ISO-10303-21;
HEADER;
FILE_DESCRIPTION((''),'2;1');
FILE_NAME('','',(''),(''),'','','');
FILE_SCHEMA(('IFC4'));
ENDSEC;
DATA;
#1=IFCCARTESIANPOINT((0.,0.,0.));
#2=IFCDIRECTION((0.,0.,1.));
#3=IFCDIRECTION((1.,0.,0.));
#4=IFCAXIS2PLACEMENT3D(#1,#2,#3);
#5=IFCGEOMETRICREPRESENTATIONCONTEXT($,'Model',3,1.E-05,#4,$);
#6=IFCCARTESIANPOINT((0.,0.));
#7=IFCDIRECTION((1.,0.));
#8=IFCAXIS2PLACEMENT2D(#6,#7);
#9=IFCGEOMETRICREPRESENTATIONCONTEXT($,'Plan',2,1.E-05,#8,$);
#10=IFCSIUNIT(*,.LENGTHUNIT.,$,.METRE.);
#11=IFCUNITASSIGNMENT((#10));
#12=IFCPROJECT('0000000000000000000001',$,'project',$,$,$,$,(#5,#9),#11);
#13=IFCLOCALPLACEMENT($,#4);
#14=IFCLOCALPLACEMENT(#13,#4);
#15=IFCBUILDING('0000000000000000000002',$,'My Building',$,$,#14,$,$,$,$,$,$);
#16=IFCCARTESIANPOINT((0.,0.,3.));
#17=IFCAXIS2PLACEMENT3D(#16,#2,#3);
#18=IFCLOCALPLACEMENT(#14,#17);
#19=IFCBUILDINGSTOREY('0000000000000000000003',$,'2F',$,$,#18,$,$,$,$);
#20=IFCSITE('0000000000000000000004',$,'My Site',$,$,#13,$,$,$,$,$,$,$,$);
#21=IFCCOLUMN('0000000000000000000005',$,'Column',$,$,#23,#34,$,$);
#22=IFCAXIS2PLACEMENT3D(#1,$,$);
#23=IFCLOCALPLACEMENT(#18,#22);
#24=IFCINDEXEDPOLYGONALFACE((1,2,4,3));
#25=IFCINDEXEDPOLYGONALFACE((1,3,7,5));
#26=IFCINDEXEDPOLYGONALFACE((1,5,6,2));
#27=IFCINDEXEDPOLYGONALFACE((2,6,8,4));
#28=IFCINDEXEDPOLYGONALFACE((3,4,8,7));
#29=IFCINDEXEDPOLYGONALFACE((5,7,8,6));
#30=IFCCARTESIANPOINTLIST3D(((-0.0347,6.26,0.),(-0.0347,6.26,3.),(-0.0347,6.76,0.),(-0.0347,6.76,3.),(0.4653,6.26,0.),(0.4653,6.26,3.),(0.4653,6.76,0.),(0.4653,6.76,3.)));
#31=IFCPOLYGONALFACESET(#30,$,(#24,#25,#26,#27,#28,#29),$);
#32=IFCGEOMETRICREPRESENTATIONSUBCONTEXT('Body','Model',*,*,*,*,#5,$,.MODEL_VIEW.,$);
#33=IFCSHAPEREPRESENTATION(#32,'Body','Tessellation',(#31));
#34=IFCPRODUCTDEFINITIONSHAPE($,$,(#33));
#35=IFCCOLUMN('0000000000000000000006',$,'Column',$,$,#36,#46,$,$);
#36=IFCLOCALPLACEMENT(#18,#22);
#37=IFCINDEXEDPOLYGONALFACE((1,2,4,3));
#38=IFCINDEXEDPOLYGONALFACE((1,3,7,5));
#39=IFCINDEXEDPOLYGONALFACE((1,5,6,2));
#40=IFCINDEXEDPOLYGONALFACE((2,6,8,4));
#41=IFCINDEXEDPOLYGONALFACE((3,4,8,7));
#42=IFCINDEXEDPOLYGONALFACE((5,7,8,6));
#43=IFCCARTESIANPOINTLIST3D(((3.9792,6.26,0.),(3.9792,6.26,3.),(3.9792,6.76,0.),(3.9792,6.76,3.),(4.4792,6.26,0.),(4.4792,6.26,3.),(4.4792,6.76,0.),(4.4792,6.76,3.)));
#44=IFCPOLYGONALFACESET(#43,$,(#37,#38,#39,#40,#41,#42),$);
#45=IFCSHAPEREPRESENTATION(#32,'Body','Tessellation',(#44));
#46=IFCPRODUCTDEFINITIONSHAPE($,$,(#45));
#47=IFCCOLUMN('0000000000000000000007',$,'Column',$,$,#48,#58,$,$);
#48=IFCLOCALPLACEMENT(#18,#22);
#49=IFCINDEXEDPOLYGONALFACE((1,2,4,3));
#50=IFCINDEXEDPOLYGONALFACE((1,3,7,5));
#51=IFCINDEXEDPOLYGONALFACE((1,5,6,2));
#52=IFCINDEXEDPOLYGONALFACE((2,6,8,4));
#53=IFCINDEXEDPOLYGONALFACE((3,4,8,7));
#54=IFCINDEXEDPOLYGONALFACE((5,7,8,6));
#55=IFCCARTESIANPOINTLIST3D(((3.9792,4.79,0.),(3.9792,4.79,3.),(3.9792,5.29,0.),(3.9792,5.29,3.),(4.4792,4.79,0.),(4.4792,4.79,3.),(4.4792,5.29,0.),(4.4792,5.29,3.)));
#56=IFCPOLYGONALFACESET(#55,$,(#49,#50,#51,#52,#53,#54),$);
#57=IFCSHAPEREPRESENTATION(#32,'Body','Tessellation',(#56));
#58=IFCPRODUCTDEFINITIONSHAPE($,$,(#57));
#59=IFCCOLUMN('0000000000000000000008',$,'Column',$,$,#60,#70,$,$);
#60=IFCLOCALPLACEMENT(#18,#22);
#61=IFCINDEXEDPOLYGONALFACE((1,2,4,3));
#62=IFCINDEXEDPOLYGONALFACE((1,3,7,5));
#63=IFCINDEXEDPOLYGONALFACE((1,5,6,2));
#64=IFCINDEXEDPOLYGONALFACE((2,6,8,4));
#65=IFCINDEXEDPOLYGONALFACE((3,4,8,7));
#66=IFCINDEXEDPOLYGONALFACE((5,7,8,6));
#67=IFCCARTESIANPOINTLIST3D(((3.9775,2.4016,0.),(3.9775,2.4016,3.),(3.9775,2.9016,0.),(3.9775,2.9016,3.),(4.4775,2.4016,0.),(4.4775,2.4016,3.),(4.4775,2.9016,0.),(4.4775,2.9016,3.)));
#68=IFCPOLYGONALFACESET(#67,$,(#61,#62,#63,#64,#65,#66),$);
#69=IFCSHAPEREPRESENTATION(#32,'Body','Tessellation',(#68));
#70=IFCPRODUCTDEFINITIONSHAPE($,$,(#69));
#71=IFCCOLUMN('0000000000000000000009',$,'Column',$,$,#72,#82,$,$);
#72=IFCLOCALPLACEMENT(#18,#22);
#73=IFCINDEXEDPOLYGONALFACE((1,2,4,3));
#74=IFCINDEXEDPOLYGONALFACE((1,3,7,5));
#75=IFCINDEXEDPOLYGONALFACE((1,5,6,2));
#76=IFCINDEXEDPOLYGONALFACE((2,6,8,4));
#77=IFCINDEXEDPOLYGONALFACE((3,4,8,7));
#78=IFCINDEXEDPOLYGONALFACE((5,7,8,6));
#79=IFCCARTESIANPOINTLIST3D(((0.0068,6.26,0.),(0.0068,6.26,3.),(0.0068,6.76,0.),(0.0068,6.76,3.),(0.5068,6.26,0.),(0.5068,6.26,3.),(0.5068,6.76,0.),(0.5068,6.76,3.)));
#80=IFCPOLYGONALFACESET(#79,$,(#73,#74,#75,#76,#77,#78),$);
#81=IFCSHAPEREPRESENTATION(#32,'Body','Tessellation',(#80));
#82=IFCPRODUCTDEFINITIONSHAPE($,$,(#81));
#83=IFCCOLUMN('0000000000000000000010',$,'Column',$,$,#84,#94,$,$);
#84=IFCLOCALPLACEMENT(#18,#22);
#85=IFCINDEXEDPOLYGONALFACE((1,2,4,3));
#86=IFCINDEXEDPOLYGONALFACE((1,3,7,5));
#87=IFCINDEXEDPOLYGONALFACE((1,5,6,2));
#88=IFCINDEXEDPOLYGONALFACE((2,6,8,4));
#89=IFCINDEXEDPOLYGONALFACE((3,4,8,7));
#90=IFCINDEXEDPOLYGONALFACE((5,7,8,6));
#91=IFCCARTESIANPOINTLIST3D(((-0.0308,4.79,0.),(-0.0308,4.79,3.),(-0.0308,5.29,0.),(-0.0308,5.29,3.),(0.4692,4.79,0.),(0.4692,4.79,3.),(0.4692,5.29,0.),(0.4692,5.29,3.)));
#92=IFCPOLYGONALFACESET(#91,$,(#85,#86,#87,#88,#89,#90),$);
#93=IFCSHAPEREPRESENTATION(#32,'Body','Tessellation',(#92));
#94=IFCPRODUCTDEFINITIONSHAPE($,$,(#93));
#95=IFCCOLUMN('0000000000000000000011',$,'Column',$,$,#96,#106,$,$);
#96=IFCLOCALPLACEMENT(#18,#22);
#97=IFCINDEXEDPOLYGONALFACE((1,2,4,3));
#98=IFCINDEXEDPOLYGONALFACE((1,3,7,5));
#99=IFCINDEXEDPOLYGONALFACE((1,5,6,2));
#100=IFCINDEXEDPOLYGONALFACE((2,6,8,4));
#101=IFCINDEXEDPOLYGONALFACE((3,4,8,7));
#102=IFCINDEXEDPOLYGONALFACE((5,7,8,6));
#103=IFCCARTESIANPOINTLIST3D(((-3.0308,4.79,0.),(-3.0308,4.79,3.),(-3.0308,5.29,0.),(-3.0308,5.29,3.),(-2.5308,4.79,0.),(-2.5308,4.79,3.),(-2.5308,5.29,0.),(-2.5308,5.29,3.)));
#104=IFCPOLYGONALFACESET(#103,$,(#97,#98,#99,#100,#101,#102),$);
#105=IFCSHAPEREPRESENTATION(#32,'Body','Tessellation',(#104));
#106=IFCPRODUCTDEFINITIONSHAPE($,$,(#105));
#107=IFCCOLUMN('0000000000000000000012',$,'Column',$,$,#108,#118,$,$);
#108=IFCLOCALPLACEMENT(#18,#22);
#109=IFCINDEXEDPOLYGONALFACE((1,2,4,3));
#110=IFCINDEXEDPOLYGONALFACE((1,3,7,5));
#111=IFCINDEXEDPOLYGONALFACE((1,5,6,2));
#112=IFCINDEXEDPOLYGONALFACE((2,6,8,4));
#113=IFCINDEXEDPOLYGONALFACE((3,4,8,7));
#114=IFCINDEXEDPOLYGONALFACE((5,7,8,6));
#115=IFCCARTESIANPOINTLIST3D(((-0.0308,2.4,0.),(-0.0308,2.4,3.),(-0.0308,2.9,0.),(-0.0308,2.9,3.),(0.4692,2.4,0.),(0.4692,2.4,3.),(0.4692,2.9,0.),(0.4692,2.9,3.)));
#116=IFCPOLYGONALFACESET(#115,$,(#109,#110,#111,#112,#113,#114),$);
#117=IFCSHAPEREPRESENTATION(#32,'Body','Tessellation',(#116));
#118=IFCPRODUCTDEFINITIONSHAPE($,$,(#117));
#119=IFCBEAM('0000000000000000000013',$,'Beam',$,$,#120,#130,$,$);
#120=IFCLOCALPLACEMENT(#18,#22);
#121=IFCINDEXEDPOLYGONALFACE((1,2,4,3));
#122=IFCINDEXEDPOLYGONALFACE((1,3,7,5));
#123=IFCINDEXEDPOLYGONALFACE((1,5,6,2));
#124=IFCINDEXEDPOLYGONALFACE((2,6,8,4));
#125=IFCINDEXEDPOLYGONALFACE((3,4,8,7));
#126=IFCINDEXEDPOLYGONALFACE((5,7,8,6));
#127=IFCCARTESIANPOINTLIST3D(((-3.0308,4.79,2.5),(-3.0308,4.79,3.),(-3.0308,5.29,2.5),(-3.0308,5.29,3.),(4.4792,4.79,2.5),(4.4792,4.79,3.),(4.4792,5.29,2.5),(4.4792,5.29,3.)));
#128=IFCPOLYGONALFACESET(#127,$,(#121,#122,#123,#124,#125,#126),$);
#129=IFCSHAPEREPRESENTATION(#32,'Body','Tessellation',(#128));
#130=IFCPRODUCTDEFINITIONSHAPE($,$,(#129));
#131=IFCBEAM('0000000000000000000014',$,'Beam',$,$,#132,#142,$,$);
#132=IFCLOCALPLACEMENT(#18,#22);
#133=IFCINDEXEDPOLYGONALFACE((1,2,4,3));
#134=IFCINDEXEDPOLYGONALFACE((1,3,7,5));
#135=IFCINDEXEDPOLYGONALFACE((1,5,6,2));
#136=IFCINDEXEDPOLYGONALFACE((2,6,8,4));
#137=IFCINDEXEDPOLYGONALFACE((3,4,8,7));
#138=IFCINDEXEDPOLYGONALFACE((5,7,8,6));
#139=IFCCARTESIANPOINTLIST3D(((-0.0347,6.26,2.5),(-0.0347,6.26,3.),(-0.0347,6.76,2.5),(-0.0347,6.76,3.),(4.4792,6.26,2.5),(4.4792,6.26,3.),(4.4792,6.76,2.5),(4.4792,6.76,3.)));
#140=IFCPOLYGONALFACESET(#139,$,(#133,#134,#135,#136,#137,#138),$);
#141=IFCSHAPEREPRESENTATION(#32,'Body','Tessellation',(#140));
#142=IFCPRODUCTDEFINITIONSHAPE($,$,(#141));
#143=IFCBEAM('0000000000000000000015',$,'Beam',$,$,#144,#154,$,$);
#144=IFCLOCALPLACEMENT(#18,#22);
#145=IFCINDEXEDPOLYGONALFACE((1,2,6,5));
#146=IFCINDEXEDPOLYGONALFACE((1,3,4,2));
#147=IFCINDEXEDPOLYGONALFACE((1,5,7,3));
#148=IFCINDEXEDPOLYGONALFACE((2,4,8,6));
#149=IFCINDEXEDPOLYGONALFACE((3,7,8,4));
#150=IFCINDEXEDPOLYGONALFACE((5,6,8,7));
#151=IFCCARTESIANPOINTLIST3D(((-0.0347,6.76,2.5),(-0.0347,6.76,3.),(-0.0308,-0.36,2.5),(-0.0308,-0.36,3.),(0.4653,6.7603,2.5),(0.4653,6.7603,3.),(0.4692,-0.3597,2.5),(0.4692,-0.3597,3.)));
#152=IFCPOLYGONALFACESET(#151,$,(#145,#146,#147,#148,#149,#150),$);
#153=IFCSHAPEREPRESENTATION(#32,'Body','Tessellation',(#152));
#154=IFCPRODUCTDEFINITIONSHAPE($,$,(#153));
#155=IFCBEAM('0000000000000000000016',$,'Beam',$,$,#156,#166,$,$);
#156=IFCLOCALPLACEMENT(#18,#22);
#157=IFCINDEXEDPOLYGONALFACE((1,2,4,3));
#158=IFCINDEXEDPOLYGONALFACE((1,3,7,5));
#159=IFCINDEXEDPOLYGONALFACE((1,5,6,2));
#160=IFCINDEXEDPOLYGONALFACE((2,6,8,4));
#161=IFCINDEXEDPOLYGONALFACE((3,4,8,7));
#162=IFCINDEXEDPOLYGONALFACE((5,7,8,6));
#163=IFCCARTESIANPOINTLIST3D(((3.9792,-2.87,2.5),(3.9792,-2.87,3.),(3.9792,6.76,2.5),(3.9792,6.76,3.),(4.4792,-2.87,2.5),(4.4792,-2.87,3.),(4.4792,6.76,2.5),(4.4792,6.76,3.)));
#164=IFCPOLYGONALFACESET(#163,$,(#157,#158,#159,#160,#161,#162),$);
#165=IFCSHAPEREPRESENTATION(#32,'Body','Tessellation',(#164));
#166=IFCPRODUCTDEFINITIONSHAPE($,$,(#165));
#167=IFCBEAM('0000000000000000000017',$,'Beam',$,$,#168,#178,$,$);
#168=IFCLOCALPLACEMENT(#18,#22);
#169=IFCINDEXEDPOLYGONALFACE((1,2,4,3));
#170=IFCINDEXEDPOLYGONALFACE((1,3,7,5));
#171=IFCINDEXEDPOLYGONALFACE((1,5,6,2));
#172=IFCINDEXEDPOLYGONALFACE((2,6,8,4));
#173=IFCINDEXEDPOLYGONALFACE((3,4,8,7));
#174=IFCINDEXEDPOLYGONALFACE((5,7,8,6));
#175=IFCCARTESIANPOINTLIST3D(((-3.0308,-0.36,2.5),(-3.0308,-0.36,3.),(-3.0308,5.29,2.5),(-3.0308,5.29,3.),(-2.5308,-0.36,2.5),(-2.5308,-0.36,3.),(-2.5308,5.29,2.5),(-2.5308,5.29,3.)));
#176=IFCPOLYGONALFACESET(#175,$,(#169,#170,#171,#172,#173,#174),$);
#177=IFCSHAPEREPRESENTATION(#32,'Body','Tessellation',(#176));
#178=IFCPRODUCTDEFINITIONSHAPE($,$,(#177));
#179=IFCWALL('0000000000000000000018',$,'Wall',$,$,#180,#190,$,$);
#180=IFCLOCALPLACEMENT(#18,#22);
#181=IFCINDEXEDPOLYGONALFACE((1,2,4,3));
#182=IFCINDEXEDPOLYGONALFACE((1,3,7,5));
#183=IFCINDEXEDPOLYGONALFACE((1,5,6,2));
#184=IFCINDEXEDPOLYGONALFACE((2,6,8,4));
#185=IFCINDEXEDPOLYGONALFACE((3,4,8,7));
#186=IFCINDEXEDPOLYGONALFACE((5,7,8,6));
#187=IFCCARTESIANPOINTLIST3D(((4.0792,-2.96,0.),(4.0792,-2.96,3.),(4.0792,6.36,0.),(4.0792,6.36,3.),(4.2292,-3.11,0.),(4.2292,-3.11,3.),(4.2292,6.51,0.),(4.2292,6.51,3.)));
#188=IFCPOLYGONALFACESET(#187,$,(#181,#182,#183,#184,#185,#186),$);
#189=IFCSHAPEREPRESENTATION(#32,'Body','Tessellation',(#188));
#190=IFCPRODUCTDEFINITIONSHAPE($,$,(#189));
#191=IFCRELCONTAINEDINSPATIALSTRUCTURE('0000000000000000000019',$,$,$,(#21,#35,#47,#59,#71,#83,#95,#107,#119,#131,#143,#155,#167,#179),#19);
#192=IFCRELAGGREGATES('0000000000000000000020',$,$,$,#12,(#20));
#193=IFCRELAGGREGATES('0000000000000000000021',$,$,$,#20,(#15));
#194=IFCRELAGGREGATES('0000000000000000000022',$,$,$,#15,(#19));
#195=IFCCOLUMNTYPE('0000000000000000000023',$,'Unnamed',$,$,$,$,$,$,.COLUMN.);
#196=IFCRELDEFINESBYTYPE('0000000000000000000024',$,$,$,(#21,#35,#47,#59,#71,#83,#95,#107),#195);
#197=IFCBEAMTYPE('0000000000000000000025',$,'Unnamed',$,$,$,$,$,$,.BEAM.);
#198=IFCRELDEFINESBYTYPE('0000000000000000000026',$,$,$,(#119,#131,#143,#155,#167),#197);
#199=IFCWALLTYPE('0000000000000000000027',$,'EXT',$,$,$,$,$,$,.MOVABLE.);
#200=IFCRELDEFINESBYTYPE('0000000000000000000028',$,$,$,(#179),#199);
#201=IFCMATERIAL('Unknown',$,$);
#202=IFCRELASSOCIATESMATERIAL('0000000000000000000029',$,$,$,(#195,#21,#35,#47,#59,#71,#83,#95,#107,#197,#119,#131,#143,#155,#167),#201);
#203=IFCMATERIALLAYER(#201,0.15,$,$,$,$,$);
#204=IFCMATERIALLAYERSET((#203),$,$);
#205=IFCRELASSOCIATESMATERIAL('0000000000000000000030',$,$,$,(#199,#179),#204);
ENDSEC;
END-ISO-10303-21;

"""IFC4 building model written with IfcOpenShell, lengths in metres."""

from ifc_helpers import new_model, si_unit, frame, origin_with_axes, origin_2d_with_axis, place, context, subcontext, project, spatial, line, indexed_curve, rectangle, outline, extrude, material, layer, layer_set, layer_usage, material_profile, profile_set, profile_usage, type_object, element, save


model = new_model("IFC4")

# Units and contexts
model_context = context("Model", 3, precision=1e-05, world=origin_with_axes())
plan_context = context("Plan", 2, precision=1e-05, world=origin_2d_with_axis())
body_context_1 = subcontext(model_context, "Body", "Model", "MODEL_VIEW")
ifc_project = project(units=[si_unit("LENGTHUNIT", "METRE")], contexts=[model_context, plan_context])

# Site, building, storey
site_placement = place(None, origin_with_axes())
site = spatial("IfcSite", under=ifc_project, at=site_placement, Name="My Site")
building_placement = place(site_placement, origin_with_axes())
building = spatial("IfcBuilding", under=site, at=building_placement, Name="My Building")
storey_placement = place(building_placement, frame((0.0, 0.0, 3.0), z_axis=(0.0, 0.0, 1.0), x_axis=(1.0, 0.0, 0.0)))
storey = spatial("IfcBuildingStorey", under=building, at=storey_placement, Name="2F")

# Columns
ifc_material = material(Name="Unknown")
ifc_material_profile_1 = material_profile(ifc_material, rectangle(XDim=0.5, YDim=0.5))
ifc_profile_set_1 = profile_set([ifc_material_profile_1])
ifc_profile_usage_1 = profile_usage(ifc_profile_set_1, cardinal=5)
column_type = type_object("IfcColumnType", Name="Unnamed", PredefinedType="COLUMN", material=ifc_profile_set_1)
column_1_placement = place(storey_placement, frame((0.2153, 6.51, 0.0), z_axis=(0.0, 0.0, 1.0), x_axis=(1.0, 0.0, 0.0)))
element("IfcColumn", 1, at=column_1_placement, inside=storey, type_object=column_type, material=ifc_profile_usage_1, Name="Column", context=body_context_1, shape_type="SweptSolid", body=[
    extrude(rectangle(XDim=0.5, YDim=0.5), origin_with_axes(), (0.0, 0.0, 1.0), 3.0),
])
ifc_profile_usage_2 = profile_usage(ifc_profile_set_1, cardinal=5)
column_2_placement = place(storey_placement, frame((4.2292, 6.51, 0.0), z_axis=(0.0, 0.0, 1.0), x_axis=(1.0, 0.0, 0.0)))
element("IfcColumn", 2, at=column_2_placement, inside=storey, type_object=column_type, material=ifc_profile_usage_2, Name="Column", context=body_context_1, shape_type="SweptSolid", body=[
    extrude(rectangle(XDim=0.5, YDim=0.5), origin_with_axes(), (0.0, 0.0, 1.0), 3.0),
])
ifc_profile_usage_3 = profile_usage(ifc_profile_set_1, cardinal=7)
column_3_placement = place(storey_placement, frame((4.4792, 5.29, 0.0), z_axis=(0.0, 0.0, 1.0), x_axis=(1.0, 0.0, 0.0)))
element("IfcColumn", 3, at=column_3_placement, inside=storey, type_object=column_type, material=ifc_profile_usage_3, Name="Column", context=body_context_1, shape_type="SweptSolid", body=[
    extrude(rectangle(XDim=0.5, YDim=0.5), frame((-0.25, -0.25, 0.0), z_axis=(0.0, 0.0, 1.0), x_axis=(1.0, 0.0, 0.0)), (0.0, 0.0, 1.0), 3.0),
])
ifc_profile_usage_4 = profile_usage(ifc_profile_set_1, cardinal=7)
column_4_placement = place(storey_placement, frame((4.4775, 2.9016, 0.0), z_axis=(0.0, 0.0, 1.0), x_axis=(1.0, 0.0, 0.0)))
element("IfcColumn", 4, at=column_4_placement, inside=storey, type_object=column_type, material=ifc_profile_usage_4, Name="Column", context=body_context_1, shape_type="SweptSolid", body=[
    extrude(rectangle(XDim=0.5, YDim=0.5), frame((-0.25, -0.25, 0.0), z_axis=(0.0, 0.0, 1.0), x_axis=(1.0, 0.0, 0.0)), (0.0, 0.0, 1.0), 3.0),
])
ifc_profile_usage_5 = profile_usage(ifc_profile_set_1, cardinal=9)
column_5_placement = place(storey_placement, frame((0.0068, 6.76, 0.0), z_axis=(0.0, 0.0, 1.0), x_axis=(1.0, 0.0, 0.0)))
element("IfcColumn", 5, at=column_5_placement, inside=storey, type_object=column_type, material=ifc_profile_usage_5, Name="Column", context=body_context_1, shape_type="SweptSolid", body=[
    extrude(rectangle(XDim=0.5, YDim=0.5), frame((0.25, -0.25, 0.0), z_axis=(0.0, 0.0, 1.0), x_axis=(1.0, 0.0, 0.0)), (0.0, 0.0, 1.0), 3.0),
])
ifc_profile_usage_6 = profile_usage(ifc_profile_set_1, cardinal=9)
column_6_placement = place(storey_placement, frame((-0.0308, 5.29, 0.0), z_axis=(0.0, 0.0, 1.0), x_axis=(1.0, 0.0, 0.0)))
element("IfcColumn", 6, at=column_6_placement, inside=storey, type_object=column_type, material=ifc_profile_usage_6, Name="Column", context=body_context_1, shape_type="SweptSolid", body=[
    extrude(rectangle(XDim=0.5, YDim=0.5), frame((0.25, -0.25, 0.0), z_axis=(0.0, 0.0, 1.0), x_axis=(1.0, 0.0, 0.0)), (0.0, 0.0, 1.0), 3.0),
])
ifc_profile_usage_7 = profile_usage(ifc_profile_set_1, cardinal=9)
column_7_placement = place(storey_placement, frame((-3.0308, 5.29, 0.0), z_axis=(0.0, 0.0, 1.0), x_axis=(1.0, 0.0, 0.0)))
element("IfcColumn", 7, at=column_7_placement, inside=storey, type_object=column_type, material=ifc_profile_usage_7, Name="Column", context=body_context_1, shape_type="SweptSolid", body=[
    extrude(rectangle(XDim=0.5, YDim=0.5), frame((0.25, -0.25, 0.0), z_axis=(0.0, 0.0, 1.0), x_axis=(1.0, 0.0, 0.0)), (0.0, 0.0, 1.0), 3.0),
])
ifc_profile_usage_8 = profile_usage(ifc_profile_set_1, cardinal=9)
column_8_placement = place(storey_placement, frame((-0.0308, 2.9, 0.0), z_axis=(0.0, 0.0, 1.0), x_axis=(1.0, 0.0, 0.0)))
element("IfcColumn", 8, at=column_8_placement, inside=storey, type_object=column_type, material=ifc_profile_usage_8, Name="Column", context=body_context_1, shape_type="SweptSolid", body=[
    extrude(rectangle(XDim=0.5, YDim=0.5), frame((0.25, -0.25, 0.0), z_axis=(0.0, 0.0, 1.0), x_axis=(1.0, 0.0, 0.0)), (0.0, 0.0, 1.0), 3.0),
])

# Beams
ifc_material_profile_2 = material_profile(ifc_material, rectangle(XDim=0.5, YDim=0.5))
ifc_profile_set_2 = profile_set([ifc_material_profile_2])
ifc_profile_usage_9 = profile_usage(ifc_profile_set_2, cardinal=9)
beam_type = type_object("IfcBeamType", Name="Unnamed", PredefinedType="BEAM", material=ifc_profile_set_2)
beam_1_placement = place(storey_placement, frame((-3.0308, 4.79, 3.0), z_axis=(1.0, 0.0, 0.0), x_axis=(0.0, 1.0, 0.0)))
element("IfcBeam", 9, at=beam_1_placement, inside=storey, type_object=beam_type, material=ifc_profile_usage_9, Name="Beam", context=body_context_1, shape_type="SweptSolid", body=[
    extrude(rectangle(XDim=0.5, YDim=0.5), frame((0.25, -0.25, 0.0), z_axis=(0.0, 0.0, 1.0), x_axis=(1.0, 0.0, 0.0)), (0.0, 0.0, 1.0), 7.51),
])
ifc_profile_usage_10 = profile_usage(ifc_profile_set_2, cardinal=9)
beam_2_placement = place(storey_placement, frame((-0.0347, 6.26, 3.0), z_axis=(1.0, 0.0, 0.0), x_axis=(0.0, 1.0, 0.0)))
element("IfcBeam", 10, at=beam_2_placement, inside=storey, type_object=beam_type, material=ifc_profile_usage_10, Name="Beam", context=body_context_1, shape_type="SweptSolid", body=[
    extrude(rectangle(XDim=0.5, YDim=0.5), frame((0.25, -0.25, 0.0), z_axis=(0.0, 0.0, 1.0), x_axis=(1.0, 0.0, 0.0)), (0.0, 0.0, 1.0), 4.5139),
])
ifc_profile_usage_11 = profile_usage(ifc_profile_set_2, cardinal=9)
beam_3_placement = place(storey_placement, frame((-0.0347, 6.76, 3.0), z_axis=(0.000548, -1.0, 0.0), x_axis=(1.0, 0.000548, 0.0)))
element("IfcBeam", 11, at=beam_3_placement, inside=storey, type_object=beam_type, material=ifc_profile_usage_11, Name="Beam", context=body_context_1, shape_type="SweptSolid", body=[
    extrude(rectangle(XDim=0.5, YDim=0.5), frame((0.25, -0.25, 0.0), z_axis=(0.0, 0.0, 1.0), x_axis=(1.0, 0.0, 0.0)), (0.0, 0.0, 1.0), 7.12),
])
ifc_profile_usage_12 = profile_usage(ifc_profile_set_2, cardinal=7)
beam_4_placement = place(storey_placement, frame((4.4792, 6.76, 3.0), z_axis=(0.0, -1.0, 0.0), x_axis=(1.0, 0.0, 0.0)))
element("IfcBeam", 12, at=beam_4_placement, inside=storey, type_object=beam_type, material=ifc_profile_usage_12, Name="Beam", context=body_context_1, shape_type="SweptSolid", body=[
    extrude(rectangle(XDim=0.5, YDim=0.5), frame((-0.25, -0.25, 0.0), z_axis=(0.0, 0.0, 1.0), x_axis=(1.0, 0.0, 0.0)), (0.0, 0.0, 1.0), 9.63),
])
ifc_profile_usage_13 = profile_usage(ifc_profile_set_2, cardinal=9)
beam_5_placement = place(storey_placement, frame((-3.0308, 5.29, 3.0), z_axis=(0.0, -1.0, 0.0), x_axis=(1.0, 0.0, 0.0)))
element("IfcBeam", 13, at=beam_5_placement, inside=storey, type_object=beam_type, material=ifc_profile_usage_13, Name="Beam", context=body_context_1, shape_type="SweptSolid", body=[
    extrude(rectangle(XDim=0.5, YDim=0.5), frame((0.25, -0.25, 0.0), z_axis=(0.0, 0.0, 1.0), x_axis=(1.0, 0.0, 0.0)), (0.0, 0.0, 1.0), 5.65),
])

# Wall
ifc_layer_1 = layer(ifc_material, 0.15)
ifc_layer_set_1 = layer_set([ifc_layer_1])
ifc_layer_usage_1 = layer_usage(ifc_layer_set_1, "AXIS2", "POSITIVE", -0.15)
wall_type_1 = type_object("IfcWallType", Name="EXT", PredefinedType="MOVABLE", material=ifc_layer_set_1)
wall_1_placement = place(storey_placement, frame((4.2292, 6.51, 0.0), z_axis=(0.0, 0.0, 1.0), x_axis=(0.0, -1.0, 0.0)))
element("IfcWall", 14, at=wall_1_placement, inside=storey, type_object=wall_type_1, material=ifc_layer_usage_1, Name="Wall", context=body_context_1, shape_type="SweptSolid", body=[
    extrude(outline(indexed_curve([(0.15, -0.15), (0.0, 0.0), (9.62, 0.0), (9.47, -0.15)], segments=[line(1, 2, 3, 4, 1)])), origin_with_axes(), (0.0, 0.0, 1.0), 3.0),
])

save(model, "model.ifc")
